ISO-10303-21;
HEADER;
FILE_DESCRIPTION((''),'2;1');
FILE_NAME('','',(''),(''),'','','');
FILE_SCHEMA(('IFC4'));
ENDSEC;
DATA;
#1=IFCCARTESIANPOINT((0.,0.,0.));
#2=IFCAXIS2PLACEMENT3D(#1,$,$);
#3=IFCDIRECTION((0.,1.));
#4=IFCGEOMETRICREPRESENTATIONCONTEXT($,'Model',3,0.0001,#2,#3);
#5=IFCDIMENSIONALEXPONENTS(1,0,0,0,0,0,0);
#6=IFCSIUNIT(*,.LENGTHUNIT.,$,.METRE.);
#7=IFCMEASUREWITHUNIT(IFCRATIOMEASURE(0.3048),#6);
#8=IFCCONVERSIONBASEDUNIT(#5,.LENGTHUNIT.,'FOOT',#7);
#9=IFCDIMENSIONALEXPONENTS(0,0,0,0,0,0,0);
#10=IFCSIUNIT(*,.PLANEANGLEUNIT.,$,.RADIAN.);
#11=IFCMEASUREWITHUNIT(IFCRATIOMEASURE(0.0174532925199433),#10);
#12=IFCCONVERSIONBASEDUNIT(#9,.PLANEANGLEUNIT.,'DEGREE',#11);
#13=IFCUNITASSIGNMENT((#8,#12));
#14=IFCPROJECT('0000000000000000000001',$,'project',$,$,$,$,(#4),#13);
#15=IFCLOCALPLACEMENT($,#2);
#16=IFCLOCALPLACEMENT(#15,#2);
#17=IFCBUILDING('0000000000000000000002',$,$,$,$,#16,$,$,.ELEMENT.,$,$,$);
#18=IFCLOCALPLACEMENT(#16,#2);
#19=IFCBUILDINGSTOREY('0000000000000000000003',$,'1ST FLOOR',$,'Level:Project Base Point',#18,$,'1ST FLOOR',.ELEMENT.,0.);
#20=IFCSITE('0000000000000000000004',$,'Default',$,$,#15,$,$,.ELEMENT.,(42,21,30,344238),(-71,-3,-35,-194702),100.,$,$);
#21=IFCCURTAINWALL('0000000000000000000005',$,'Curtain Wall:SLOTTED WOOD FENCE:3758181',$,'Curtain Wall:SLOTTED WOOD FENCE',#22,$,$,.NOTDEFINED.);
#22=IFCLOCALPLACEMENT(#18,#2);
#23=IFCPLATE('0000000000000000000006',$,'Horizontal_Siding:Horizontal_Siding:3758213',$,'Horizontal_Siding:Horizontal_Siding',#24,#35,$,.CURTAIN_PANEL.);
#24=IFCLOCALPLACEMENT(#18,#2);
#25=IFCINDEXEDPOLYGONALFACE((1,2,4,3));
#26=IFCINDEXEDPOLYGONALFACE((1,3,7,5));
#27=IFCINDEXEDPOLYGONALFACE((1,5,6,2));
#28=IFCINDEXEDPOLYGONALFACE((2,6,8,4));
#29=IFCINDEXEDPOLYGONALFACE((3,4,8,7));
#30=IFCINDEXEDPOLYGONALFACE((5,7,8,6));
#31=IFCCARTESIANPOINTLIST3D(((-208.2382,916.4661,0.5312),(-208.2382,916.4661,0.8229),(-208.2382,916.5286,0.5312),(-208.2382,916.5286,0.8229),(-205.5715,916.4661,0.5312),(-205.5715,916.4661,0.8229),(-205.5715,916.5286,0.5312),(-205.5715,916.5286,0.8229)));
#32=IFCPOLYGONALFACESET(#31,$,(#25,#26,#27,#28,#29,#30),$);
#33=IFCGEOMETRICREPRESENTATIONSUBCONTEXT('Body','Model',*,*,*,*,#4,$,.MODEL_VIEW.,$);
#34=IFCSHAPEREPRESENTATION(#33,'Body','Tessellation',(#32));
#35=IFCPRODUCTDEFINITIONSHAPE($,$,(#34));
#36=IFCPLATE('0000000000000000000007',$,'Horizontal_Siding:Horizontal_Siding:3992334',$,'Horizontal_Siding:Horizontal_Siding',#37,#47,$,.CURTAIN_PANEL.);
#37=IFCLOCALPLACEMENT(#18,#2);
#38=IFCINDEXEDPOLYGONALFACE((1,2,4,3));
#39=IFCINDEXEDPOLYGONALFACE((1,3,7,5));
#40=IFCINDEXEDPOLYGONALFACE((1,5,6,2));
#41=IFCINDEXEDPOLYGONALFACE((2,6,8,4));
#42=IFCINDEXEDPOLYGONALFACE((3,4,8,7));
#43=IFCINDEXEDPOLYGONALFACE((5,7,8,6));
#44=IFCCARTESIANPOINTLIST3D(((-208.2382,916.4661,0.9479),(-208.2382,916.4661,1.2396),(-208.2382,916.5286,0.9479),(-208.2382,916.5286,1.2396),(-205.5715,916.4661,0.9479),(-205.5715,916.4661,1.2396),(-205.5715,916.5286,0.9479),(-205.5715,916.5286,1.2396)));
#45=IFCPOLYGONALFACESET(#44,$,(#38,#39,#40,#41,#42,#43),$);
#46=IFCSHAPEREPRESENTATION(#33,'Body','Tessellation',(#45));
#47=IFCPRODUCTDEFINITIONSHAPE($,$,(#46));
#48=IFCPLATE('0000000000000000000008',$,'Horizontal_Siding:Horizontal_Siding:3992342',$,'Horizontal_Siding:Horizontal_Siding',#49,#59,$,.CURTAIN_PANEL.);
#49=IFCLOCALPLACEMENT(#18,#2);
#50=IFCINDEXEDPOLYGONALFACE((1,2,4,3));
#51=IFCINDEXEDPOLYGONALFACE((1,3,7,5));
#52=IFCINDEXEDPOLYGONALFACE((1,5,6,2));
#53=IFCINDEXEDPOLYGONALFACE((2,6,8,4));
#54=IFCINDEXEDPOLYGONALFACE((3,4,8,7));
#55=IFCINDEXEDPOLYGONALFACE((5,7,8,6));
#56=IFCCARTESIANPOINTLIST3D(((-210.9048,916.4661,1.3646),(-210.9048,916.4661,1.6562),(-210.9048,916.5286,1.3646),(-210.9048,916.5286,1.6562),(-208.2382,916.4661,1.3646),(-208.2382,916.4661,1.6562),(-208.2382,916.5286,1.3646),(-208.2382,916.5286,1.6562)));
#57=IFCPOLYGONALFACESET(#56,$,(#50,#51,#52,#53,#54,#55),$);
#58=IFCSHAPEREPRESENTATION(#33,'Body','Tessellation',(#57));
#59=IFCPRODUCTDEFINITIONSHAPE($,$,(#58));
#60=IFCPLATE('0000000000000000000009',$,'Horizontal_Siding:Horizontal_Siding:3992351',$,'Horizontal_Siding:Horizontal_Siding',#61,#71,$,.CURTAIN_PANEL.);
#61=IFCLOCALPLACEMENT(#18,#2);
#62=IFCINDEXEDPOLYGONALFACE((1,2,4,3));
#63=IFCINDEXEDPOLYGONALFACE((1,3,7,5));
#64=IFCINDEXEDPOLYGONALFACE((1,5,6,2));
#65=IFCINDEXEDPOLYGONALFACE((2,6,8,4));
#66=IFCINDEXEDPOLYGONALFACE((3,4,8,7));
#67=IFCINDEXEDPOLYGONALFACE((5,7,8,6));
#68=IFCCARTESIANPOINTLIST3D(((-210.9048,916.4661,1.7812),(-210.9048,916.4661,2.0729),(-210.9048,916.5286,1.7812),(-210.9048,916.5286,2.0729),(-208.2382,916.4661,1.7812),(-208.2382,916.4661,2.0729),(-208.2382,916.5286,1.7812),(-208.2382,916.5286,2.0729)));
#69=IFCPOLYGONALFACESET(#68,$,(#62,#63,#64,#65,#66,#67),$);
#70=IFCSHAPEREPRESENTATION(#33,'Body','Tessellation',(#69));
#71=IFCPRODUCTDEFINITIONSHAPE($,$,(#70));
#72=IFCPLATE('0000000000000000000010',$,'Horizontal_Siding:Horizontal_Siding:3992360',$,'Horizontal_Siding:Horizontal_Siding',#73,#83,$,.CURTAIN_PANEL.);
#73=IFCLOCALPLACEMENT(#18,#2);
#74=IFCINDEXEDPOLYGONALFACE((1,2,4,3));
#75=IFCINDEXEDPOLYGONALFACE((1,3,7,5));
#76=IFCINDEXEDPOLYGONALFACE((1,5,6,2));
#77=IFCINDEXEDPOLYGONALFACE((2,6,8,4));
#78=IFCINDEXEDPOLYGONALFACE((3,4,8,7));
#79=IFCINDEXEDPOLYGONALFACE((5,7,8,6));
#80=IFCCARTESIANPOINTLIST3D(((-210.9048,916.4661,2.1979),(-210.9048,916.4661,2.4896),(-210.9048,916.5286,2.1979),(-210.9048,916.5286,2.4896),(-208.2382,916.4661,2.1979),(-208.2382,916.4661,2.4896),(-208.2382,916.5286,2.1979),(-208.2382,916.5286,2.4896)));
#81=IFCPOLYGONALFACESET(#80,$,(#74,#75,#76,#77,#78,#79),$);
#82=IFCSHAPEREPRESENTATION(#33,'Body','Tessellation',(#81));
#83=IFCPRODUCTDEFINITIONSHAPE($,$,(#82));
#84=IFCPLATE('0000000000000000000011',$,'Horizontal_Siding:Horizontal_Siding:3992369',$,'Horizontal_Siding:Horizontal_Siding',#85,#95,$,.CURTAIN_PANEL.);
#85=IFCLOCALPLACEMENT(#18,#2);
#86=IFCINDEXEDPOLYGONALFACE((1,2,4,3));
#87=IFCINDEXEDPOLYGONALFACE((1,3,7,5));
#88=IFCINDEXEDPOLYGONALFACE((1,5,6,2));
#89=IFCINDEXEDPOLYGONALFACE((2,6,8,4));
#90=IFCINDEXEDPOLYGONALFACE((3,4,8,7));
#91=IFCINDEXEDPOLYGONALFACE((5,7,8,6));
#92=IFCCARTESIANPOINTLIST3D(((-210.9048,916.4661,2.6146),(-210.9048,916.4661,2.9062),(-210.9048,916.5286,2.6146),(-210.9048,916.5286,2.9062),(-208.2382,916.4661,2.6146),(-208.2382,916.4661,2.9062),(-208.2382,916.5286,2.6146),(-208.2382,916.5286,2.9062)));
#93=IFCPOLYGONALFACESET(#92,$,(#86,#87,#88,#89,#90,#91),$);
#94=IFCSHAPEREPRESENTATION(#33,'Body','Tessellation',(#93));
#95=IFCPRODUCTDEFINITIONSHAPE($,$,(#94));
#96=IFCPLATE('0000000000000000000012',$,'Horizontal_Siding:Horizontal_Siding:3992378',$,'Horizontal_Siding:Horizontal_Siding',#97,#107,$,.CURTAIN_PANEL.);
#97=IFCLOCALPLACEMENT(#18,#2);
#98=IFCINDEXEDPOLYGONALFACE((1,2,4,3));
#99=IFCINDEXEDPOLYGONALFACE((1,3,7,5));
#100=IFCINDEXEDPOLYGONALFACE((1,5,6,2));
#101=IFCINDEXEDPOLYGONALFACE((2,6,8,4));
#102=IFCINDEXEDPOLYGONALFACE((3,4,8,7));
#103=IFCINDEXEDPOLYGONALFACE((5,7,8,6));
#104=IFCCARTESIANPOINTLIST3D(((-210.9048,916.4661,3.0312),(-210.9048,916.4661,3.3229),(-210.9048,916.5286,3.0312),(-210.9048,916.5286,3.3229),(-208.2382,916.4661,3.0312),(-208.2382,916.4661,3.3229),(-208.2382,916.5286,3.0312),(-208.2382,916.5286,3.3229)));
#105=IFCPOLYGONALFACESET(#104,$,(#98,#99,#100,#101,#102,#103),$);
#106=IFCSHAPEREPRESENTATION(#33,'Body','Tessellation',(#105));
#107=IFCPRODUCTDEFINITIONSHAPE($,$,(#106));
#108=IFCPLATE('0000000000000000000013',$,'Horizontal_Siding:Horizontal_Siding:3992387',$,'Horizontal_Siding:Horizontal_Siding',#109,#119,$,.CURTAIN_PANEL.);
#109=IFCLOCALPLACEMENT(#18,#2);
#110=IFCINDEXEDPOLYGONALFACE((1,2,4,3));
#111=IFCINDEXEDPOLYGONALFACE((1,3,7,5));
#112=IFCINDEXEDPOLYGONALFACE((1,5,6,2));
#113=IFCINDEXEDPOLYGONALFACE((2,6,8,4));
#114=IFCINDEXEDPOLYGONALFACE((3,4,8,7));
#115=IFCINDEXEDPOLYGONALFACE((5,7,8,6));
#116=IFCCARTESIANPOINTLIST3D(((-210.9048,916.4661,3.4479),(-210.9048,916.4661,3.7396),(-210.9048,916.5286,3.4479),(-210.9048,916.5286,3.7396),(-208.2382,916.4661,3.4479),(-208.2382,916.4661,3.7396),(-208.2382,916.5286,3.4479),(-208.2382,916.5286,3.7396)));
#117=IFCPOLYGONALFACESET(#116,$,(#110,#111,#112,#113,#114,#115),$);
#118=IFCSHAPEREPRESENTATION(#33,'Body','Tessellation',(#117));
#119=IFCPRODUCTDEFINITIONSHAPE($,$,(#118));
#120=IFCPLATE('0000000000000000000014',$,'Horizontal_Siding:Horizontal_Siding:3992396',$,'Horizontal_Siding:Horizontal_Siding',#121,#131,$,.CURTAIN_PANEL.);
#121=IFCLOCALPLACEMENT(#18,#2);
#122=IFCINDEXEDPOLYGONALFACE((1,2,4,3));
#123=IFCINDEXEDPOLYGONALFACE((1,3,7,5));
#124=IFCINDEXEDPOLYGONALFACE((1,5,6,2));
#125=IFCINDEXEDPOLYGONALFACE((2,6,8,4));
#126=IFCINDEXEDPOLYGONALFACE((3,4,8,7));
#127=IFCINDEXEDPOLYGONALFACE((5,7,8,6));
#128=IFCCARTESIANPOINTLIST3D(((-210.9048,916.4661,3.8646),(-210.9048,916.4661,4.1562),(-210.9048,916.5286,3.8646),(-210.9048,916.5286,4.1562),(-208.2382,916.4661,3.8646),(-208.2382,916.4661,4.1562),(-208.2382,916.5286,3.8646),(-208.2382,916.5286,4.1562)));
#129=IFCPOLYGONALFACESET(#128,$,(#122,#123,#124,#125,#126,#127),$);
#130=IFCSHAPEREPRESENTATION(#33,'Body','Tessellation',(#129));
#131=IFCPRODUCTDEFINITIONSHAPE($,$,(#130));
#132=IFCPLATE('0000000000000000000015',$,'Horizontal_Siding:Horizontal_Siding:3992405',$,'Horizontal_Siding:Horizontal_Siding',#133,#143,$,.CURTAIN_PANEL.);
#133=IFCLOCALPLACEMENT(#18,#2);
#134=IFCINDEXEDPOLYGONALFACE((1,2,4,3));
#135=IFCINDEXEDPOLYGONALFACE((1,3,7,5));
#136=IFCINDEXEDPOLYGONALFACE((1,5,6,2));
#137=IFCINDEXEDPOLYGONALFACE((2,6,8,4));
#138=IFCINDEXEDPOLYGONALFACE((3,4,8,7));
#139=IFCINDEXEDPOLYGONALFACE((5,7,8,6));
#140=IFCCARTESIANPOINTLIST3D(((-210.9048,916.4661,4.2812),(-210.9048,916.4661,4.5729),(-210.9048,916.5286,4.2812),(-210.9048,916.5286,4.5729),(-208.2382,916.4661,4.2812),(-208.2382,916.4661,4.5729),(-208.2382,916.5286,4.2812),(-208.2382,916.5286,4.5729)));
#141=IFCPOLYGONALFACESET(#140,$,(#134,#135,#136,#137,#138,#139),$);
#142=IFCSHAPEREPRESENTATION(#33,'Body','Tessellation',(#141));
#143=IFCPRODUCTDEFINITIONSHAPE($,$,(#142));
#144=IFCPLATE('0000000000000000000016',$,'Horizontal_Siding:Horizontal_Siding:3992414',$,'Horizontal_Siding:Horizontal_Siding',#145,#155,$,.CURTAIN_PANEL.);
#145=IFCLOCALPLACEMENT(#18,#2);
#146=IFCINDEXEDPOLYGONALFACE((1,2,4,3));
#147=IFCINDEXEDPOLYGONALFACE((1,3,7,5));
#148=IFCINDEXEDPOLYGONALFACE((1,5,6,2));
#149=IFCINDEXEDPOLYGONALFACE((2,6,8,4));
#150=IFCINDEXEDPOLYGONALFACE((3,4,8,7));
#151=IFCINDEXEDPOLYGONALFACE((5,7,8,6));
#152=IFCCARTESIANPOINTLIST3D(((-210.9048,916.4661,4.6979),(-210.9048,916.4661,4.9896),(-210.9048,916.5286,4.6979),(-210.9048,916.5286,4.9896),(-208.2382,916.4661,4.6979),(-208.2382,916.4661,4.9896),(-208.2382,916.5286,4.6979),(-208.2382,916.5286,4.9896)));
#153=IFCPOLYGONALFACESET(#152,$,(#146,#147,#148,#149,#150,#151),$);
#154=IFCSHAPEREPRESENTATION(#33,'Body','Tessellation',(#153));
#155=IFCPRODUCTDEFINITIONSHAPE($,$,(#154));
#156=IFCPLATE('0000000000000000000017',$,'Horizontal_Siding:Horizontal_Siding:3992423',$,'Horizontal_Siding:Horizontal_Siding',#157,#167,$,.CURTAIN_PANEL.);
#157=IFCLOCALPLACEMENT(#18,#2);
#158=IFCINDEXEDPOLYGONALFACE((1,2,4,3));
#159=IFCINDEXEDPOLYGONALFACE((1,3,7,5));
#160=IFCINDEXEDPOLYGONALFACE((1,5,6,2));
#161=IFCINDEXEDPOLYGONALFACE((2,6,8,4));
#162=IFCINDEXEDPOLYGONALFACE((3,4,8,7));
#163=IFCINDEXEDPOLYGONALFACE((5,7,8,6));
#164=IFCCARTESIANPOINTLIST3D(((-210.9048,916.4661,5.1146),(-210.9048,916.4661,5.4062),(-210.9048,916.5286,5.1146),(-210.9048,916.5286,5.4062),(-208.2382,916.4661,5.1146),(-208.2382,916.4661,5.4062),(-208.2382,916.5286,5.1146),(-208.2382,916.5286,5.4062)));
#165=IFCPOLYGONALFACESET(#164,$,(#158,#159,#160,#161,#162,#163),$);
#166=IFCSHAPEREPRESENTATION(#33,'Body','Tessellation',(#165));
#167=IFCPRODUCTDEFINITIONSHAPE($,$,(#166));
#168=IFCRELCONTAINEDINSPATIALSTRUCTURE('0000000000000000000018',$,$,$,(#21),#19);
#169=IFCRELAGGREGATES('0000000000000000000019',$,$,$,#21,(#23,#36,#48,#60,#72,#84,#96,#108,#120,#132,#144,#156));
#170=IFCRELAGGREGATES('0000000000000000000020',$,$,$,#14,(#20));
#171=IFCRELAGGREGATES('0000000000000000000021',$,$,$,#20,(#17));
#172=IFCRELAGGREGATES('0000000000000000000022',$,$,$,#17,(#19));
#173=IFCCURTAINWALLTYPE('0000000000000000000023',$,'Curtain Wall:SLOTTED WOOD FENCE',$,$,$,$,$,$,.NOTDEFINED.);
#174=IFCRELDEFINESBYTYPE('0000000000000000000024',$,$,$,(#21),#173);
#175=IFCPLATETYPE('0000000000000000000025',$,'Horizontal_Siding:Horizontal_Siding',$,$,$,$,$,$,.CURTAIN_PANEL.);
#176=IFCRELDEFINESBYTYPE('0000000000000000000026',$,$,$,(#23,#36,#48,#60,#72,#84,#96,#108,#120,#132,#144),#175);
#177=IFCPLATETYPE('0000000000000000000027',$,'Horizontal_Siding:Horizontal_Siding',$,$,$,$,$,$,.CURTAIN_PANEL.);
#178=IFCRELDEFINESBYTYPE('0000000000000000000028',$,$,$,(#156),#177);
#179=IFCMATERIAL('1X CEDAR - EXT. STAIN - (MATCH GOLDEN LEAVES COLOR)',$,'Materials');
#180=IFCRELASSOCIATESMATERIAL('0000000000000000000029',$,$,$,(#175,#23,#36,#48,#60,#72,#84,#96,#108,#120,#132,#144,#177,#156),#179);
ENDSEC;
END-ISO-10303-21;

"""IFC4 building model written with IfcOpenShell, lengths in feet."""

from ifc_helpers import new_model, entity, si_unit, converted_unit, direction, frame, origin, origin_2d_with_axis, place, context, subcontext, project, spatial, rectangle, extrude, source, transform, mapped, material, type_object, type_shapes, element, aggregate, save


model = new_model("IFC4")

# Units and contexts
model_context = context("Model", 3, precision=0.0001, world=origin(), true_north=direction((0.0, 1.0)))
body_context = subcontext(model_context, "Body", "Model", "MODEL_VIEW")
ifc_project = project(units=[converted_unit("LENGTHUNIT", "FOOT", entity("IfcRatioMeasure", 0.3048), si_unit("LENGTHUNIT", "METRE"), dimensions=[1, 0, 0, 0, 0, 0, 0]), converted_unit("PLANEANGLEUNIT", "DEGREE", entity("IfcRatioMeasure", 0.0174532925199433), si_unit("PLANEANGLEUNIT", "RADIAN"), dimensions=[0, 0, 0, 0, 0, 0, 0])], contexts=[model_context])

# Site, building, storey
site_placement = place(None, origin())
site = spatial("IfcSite", under=ifc_project, at=site_placement, Name="Default", CompositionType="ELEMENT", RefLatitude=(42, 21, 30, 344238), RefLongitude=(-71, -3, -35, -194702), RefElevation=100.0)
building_placement = place(site_placement, origin())
building = spatial("IfcBuilding", under=site, at=building_placement, CompositionType="ELEMENT")
storey_placement = place(building_placement, origin())
storey = spatial("IfcBuildingStorey", under=building, at=storey_placement, Name="1ST FLOOR", ObjectType="Level:Project Base Point", LongName="1ST FLOOR", CompositionType="ELEMENT", Elevation=0.0)

# Curtain wall, plates
curtain_wall_type = type_object("IfcCurtainWallType", Name="Curtain Wall:SLOTTED WOOD FENCE", PredefinedType="NOTDEFINED")
curtain_wall_placement = place(storey_placement, origin())
curtain_wall = element("IfcCurtainWall", 1, at=curtain_wall_placement, inside=storey, type_object=curtain_wall_type, Name="Curtain Wall:SLOTTED WOOD FENCE:3758181", ObjectType="Curtain Wall:SLOTTED WOOD FENCE", PredefinedType="NOTDEFINED")
ifc_material_1 = material(Name="1X CEDAR - EXT. STAIN - (MATCH GOLDEN LEAVES COLOR)", Category="Materials")
plate_type_1 = type_object("IfcPlateType", Name="Horizontal_Siding:Horizontal_Siding", PredefinedType="CURTAIN_PANEL", material=ifc_material_1)
shared_shape_1 = source(origin(), body_context, "Body", "SweptSolid", [
    extrude(rectangle(XDim=2.6667, YDim=0.0625, at=origin_2d_with_axis()), frame((1.3333, 0.0312, 0.0), z_axis=(0.0, 0.0, 1.0), x_axis=(-1.0, 0.0, 0.0)), (0.0, 0.0, 1.0), 0.2917),
])
type_shapes(plate_type_1, [shared_shape_1])
plate_1_placement = place(curtain_wall_placement, frame((-208.2382, 916.4661, 0.5312)))
plate_1 = element("IfcPlate", 2, at=plate_1_placement, type_object=plate_type_1, material=ifc_material_1, Name="Horizontal_Siding:Horizontal_Siding:3758213", ObjectType="Horizontal_Siding:Horizontal_Siding", PredefinedType="CURTAIN_PANEL", context=body_context, shape_type="MappedRepresentation", body=[
    mapped(shared_shape_1, transform((0.0, 0.0, 0.0), scale=1.0)),
])
plate_2_placement = place(curtain_wall_placement, frame((-208.2382, 916.4661, 0.9479)))
plate_2 = element("IfcPlate", 3, at=plate_2_placement, type_object=plate_type_1, material=ifc_material_1, Name="Horizontal_Siding:Horizontal_Siding:3992334", ObjectType="Horizontal_Siding:Horizontal_Siding", PredefinedType="CURTAIN_PANEL", context=body_context, shape_type="MappedRepresentation", body=[
    mapped(shared_shape_1, transform((0.0, 0.0, 0.0), scale=1.0)),
])
plate_3_placement = place(curtain_wall_placement, frame((-210.9048, 916.4661, 1.3646)))
plate_3 = element("IfcPlate", 4, at=plate_3_placement, type_object=plate_type_1, material=ifc_material_1, Name="Horizontal_Siding:Horizontal_Siding:3992342", ObjectType="Horizontal_Siding:Horizontal_Siding", PredefinedType="CURTAIN_PANEL", context=body_context, shape_type="MappedRepresentation", body=[
    mapped(shared_shape_1, transform((0.0, 0.0, 0.0), scale=1.0)),
])
plate_4_placement = place(curtain_wall_placement, frame((-210.9048, 916.4661, 1.7812)))
plate_4 = element("IfcPlate", 5, at=plate_4_placement, type_object=plate_type_1, material=ifc_material_1, Name="Horizontal_Siding:Horizontal_Siding:3992351", ObjectType="Horizontal_Siding:Horizontal_Siding", PredefinedType="CURTAIN_PANEL", context=body_context, shape_type="MappedRepresentation", body=[
    mapped(shared_shape_1, transform((0.0, 0.0, 0.0), scale=1.0)),
])
plate_5_placement = place(curtain_wall_placement, frame((-210.9048, 916.4661, 2.1979)))
plate_5 = element("IfcPlate", 6, at=plate_5_placement, type_object=plate_type_1, material=ifc_material_1, Name="Horizontal_Siding:Horizontal_Siding:3992360", ObjectType="Horizontal_Siding:Horizontal_Siding", PredefinedType="CURTAIN_PANEL", context=body_context, shape_type="MappedRepresentation", body=[
    mapped(shared_shape_1, transform((0.0, 0.0, 0.0), scale=1.0)),
])
plate_6_placement = place(curtain_wall_placement, frame((-210.9048, 916.4661, 2.6146)))
plate_6 = element("IfcPlate", 7, at=plate_6_placement, type_object=plate_type_1, material=ifc_material_1, Name="Horizontal_Siding:Horizontal_Siding:3992369", ObjectType="Horizontal_Siding:Horizontal_Siding", PredefinedType="CURTAIN_PANEL", context=body_context, shape_type="MappedRepresentation", body=[
    mapped(shared_shape_1, transform((0.0, 0.0, 0.0), scale=1.0)),
])
plate_7_placement = place(curtain_wall_placement, frame((-210.9048, 916.4661, 3.0312)))
plate_7 = element("IfcPlate", 8, at=plate_7_placement, type_object=plate_type_1, material=ifc_material_1, Name="Horizontal_Siding:Horizontal_Siding:3992378", ObjectType="Horizontal_Siding:Horizontal_Siding", PredefinedType="CURTAIN_PANEL", context=body_context, shape_type="MappedRepresentation", body=[
    mapped(shared_shape_1, transform((0.0, 0.0, 0.0), scale=1.0)),
])
plate_8_placement = place(curtain_wall_placement, frame((-210.9048, 916.4661, 3.4479)))
plate_8 = element("IfcPlate", 9, at=plate_8_placement, type_object=plate_type_1, material=ifc_material_1, Name="Horizontal_Siding:Horizontal_Siding:3992387", ObjectType="Horizontal_Siding:Horizontal_Siding", PredefinedType="CURTAIN_PANEL", context=body_context, shape_type="MappedRepresentation", body=[
    mapped(shared_shape_1, transform((0.0, 0.0, 0.0), scale=1.0)),
])
plate_9_placement = place(curtain_wall_placement, frame((-210.9048, 916.4661, 3.8646)))
plate_9 = element("IfcPlate", 10, at=plate_9_placement, type_object=plate_type_1, material=ifc_material_1, Name="Horizontal_Siding:Horizontal_Siding:3992396", ObjectType="Horizontal_Siding:Horizontal_Siding", PredefinedType="CURTAIN_PANEL", context=body_context, shape_type="MappedRepresentation", body=[
    mapped(shared_shape_1, transform((0.0, 0.0, 0.0), scale=1.0)),
])
plate_10_placement = place(curtain_wall_placement, frame((-210.9048, 916.4661, 4.2812)))
plate_10 = element("IfcPlate", 11, at=plate_10_placement, type_object=plate_type_1, material=ifc_material_1, Name="Horizontal_Siding:Horizontal_Siding:3992405", ObjectType="Horizontal_Siding:Horizontal_Siding", PredefinedType="CURTAIN_PANEL", context=body_context, shape_type="MappedRepresentation", body=[
    mapped(shared_shape_1, transform((0.0, 0.0, 0.0), scale=1.0)),
])
plate_11_placement = place(curtain_wall_placement, frame((-210.9048, 916.4661, 4.6979)))
plate_11 = element("IfcPlate", 12, at=plate_11_placement, type_object=plate_type_1, material=ifc_material_1, Name="Horizontal_Siding:Horizontal_Siding:3992414", ObjectType="Horizontal_Siding:Horizontal_Siding", PredefinedType="CURTAIN_PANEL", context=body_context, shape_type="MappedRepresentation", body=[
    mapped(shared_shape_1, transform((0.0, 0.0, 0.0), scale=1.0)),
])
plate_type_2 = type_object("IfcPlateType", Name="Horizontal_Siding:Horizontal_Siding", PredefinedType="CURTAIN_PANEL", material=ifc_material_1)
shared_shape_2 = source(origin(), body_context, "Body", "SweptSolid", [
    extrude(rectangle(XDim=2.6667, YDim=0.0625, at=origin_2d_with_axis()), frame((1.3333, 0.0312, 0.0), z_axis=(0.0, 0.0, 1.0), x_axis=(-1.0, 0.0, 0.0)), (0.0, 0.0, 1.0), 0.2917),
])
type_shapes(plate_type_2, [shared_shape_2])
plate_12_placement = place(curtain_wall_placement, frame((-210.9048, 916.4661, 5.1146)))
plate_12 = element("IfcPlate", 13, at=plate_12_placement, type_object=plate_type_2, material=ifc_material_1, Name="Horizontal_Siding:Horizontal_Siding:3992423", ObjectType="Horizontal_Siding:Horizontal_Siding", PredefinedType="CURTAIN_PANEL", context=body_context, shape_type="MappedRepresentation", body=[
    mapped(shared_shape_2, transform((0.0, 0.0, 0.0), scale=1.0)),
])
aggregate(curtain_wall, [plate_1, plate_2, plate_3, plate_4, plate_5, plate_6, plate_7, plate_8, plate_9, plate_10, plate_11, plate_12])

save(model, "model.ifc")
